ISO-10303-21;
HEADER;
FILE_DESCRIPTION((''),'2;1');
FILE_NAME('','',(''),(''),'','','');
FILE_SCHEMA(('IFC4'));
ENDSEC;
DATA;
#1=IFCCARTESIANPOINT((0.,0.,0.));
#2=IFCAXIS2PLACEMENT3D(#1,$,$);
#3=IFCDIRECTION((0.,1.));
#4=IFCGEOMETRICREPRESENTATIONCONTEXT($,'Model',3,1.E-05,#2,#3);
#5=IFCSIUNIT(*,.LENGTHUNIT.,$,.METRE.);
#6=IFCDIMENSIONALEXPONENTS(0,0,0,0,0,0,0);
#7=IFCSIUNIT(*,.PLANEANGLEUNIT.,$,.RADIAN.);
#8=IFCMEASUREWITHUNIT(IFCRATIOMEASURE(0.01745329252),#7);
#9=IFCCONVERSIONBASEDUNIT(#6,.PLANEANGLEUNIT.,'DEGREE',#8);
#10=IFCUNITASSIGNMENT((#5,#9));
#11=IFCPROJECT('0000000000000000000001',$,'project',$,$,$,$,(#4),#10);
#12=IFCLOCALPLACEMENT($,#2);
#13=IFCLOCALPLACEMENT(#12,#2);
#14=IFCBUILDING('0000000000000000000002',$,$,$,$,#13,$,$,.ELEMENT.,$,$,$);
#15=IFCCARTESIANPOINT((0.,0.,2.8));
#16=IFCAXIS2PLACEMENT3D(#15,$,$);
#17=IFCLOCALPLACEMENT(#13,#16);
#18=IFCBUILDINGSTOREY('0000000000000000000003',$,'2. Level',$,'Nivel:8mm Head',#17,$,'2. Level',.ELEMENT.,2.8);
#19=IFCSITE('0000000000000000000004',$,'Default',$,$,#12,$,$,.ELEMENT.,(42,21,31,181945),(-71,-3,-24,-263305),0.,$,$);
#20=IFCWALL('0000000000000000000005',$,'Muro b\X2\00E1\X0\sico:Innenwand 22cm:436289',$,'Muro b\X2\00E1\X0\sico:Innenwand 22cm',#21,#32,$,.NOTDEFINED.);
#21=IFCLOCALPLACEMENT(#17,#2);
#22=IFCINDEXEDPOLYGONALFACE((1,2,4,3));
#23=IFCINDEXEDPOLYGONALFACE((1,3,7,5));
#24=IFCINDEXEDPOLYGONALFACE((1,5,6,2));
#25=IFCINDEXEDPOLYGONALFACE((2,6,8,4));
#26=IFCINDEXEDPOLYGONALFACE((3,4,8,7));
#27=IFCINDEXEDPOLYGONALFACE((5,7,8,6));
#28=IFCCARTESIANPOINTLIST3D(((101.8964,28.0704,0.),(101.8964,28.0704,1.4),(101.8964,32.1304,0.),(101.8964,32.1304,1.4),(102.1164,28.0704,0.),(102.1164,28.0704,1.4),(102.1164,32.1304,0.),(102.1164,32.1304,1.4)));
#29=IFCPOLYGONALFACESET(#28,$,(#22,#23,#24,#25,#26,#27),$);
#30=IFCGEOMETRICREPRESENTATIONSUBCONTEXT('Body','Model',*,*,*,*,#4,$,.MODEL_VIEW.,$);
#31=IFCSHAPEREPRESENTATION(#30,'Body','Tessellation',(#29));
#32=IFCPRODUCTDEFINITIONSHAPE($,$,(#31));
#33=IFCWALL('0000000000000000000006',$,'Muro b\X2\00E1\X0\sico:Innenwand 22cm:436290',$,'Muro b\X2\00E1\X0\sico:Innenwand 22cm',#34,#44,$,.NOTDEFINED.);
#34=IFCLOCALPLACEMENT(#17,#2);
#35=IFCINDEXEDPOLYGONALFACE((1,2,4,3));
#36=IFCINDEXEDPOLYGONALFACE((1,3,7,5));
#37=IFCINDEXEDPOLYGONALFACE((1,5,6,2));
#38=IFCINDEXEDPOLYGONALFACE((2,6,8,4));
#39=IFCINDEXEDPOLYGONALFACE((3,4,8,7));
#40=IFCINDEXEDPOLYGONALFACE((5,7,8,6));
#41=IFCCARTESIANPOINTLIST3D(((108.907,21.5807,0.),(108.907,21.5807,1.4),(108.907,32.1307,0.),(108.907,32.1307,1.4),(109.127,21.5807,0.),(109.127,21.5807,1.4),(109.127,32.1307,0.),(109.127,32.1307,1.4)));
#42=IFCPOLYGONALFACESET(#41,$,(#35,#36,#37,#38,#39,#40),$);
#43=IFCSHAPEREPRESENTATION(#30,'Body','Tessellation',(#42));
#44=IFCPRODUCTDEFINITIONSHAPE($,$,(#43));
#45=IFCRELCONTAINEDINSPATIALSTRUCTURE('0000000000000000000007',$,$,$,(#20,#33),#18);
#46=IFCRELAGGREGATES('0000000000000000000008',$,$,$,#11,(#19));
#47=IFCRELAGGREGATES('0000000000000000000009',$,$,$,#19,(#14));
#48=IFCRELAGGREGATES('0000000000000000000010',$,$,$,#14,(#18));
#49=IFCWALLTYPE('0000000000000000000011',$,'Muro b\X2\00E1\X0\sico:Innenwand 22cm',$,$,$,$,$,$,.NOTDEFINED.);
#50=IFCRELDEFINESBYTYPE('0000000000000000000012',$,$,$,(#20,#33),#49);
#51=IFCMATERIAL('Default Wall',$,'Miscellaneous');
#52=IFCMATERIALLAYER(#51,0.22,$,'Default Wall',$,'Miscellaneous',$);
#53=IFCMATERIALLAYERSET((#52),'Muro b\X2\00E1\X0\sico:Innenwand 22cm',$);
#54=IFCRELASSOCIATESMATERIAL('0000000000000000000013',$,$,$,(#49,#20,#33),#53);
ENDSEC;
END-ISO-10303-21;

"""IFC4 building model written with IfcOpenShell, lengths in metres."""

from ifc_helpers import new_model, entity, si_unit, converted_unit, direction, frame, frame_2d, origin, place, context, subcontext, project, spatial, rectangle, extrude, clip, halfspace, material, layer, layer_set, layer_usage, type_object, element, save


model = new_model("IFC4")

# Units and contexts
model_context = context("Model", 3, precision=1e-05, world=origin(), true_north=direction((0.0, 1.0)))
body_context = subcontext(model_context, "Body", "Model", "MODEL_VIEW")
ifc_project = project(units=[si_unit("LENGTHUNIT", "METRE"), converted_unit("PLANEANGLEUNIT", "DEGREE", entity("IfcRatioMeasure", 0.01745329252), si_unit("PLANEANGLEUNIT", "RADIAN"), dimensions=[0, 0, 0, 0, 0, 0, 0])], contexts=[model_context])

# Site, building, storey
site_placement = place(None, origin())
site = spatial("IfcSite", under=ifc_project, at=site_placement, Name="Default", CompositionType="ELEMENT", RefLatitude=(42, 21, 31, 181945), RefLongitude=(-71, -3, -24, -263305), RefElevation=0.0)
building_placement = place(site_placement, origin())
building = spatial("IfcBuilding", under=site, at=building_placement, CompositionType="ELEMENT")
storey_placement = place(building_placement, frame((0.0, 0.0, 2.8)))
storey = spatial("IfcBuildingStorey", under=building, at=storey_placement, Name="2. Level", ObjectType="Nivel:8mm Head", LongName="2. Level", CompositionType="ELEMENT", Elevation=2.8)

# Walls
ifc_material_1 = material(Name="Default Wall", Category="Miscellaneous")
ifc_layer_1 = layer(ifc_material_1, 0.22, Name="Default Wall", Category="Miscellaneous")
ifc_layer_set_1 = layer_set([ifc_layer_1], Name="Muro básico:Innenwand 22cm")
wall_type_1 = type_object("IfcWallType", Name="Muro básico:Innenwand 22cm", PredefinedType="NOTDEFINED", material=ifc_layer_set_1)
ifc_layer_usage_1 = layer_usage(ifc_layer_set_1, "AXIS2", "NEGATIVE", 0.11)
wall_1_placement = place(storey_placement, frame((102.0064, 28.0704, 0.0), z_axis=(0.0, 0.0, 1.0), x_axis=(0.0, 1.0, 0.0)))
element("IfcWall", 1, at=wall_1_placement, inside=storey, type_object=wall_type_1, material=ifc_layer_usage_1, Name="Muro básico:Innenwand 22cm:436289", ObjectType="Muro básico:Innenwand 22cm", PredefinedType="NOTDEFINED", context=body_context, shape_type="Clipping", body=[
    clip(extrude(rectangle(XDim=4.06, YDim=0.22, at=frame_2d((2.03, 0.0), x_axis=(-1.0, 0.0))), origin(), (0.0, 0.0, 1.0), 1.4), halfspace(origin(), True)),
])
ifc_layer_usage_2 = layer_usage(ifc_layer_set_1, "AXIS2", "NEGATIVE", 0.11)
wall_2_placement = place(storey_placement, frame((109.017, 21.5807, 0.0), z_axis=(0.0, 0.0, 1.0), x_axis=(0.0, 1.0, 0.0)))
element("IfcWall", 2, at=wall_2_placement, inside=storey, type_object=wall_type_1, material=ifc_layer_usage_2, Name="Muro básico:Innenwand 22cm:436290", ObjectType="Muro básico:Innenwand 22cm", PredefinedType="NOTDEFINED", context=body_context, shape_type="Clipping", body=[
    clip(extrude(rectangle(XDim=10.55, YDim=0.22, at=frame_2d((5.275, 0.0), x_axis=(-1.0, 0.0))), origin(), (0.0, 0.0, 1.0), 1.4), halfspace(origin(), True)),
])

save(model, "model.ifc")
